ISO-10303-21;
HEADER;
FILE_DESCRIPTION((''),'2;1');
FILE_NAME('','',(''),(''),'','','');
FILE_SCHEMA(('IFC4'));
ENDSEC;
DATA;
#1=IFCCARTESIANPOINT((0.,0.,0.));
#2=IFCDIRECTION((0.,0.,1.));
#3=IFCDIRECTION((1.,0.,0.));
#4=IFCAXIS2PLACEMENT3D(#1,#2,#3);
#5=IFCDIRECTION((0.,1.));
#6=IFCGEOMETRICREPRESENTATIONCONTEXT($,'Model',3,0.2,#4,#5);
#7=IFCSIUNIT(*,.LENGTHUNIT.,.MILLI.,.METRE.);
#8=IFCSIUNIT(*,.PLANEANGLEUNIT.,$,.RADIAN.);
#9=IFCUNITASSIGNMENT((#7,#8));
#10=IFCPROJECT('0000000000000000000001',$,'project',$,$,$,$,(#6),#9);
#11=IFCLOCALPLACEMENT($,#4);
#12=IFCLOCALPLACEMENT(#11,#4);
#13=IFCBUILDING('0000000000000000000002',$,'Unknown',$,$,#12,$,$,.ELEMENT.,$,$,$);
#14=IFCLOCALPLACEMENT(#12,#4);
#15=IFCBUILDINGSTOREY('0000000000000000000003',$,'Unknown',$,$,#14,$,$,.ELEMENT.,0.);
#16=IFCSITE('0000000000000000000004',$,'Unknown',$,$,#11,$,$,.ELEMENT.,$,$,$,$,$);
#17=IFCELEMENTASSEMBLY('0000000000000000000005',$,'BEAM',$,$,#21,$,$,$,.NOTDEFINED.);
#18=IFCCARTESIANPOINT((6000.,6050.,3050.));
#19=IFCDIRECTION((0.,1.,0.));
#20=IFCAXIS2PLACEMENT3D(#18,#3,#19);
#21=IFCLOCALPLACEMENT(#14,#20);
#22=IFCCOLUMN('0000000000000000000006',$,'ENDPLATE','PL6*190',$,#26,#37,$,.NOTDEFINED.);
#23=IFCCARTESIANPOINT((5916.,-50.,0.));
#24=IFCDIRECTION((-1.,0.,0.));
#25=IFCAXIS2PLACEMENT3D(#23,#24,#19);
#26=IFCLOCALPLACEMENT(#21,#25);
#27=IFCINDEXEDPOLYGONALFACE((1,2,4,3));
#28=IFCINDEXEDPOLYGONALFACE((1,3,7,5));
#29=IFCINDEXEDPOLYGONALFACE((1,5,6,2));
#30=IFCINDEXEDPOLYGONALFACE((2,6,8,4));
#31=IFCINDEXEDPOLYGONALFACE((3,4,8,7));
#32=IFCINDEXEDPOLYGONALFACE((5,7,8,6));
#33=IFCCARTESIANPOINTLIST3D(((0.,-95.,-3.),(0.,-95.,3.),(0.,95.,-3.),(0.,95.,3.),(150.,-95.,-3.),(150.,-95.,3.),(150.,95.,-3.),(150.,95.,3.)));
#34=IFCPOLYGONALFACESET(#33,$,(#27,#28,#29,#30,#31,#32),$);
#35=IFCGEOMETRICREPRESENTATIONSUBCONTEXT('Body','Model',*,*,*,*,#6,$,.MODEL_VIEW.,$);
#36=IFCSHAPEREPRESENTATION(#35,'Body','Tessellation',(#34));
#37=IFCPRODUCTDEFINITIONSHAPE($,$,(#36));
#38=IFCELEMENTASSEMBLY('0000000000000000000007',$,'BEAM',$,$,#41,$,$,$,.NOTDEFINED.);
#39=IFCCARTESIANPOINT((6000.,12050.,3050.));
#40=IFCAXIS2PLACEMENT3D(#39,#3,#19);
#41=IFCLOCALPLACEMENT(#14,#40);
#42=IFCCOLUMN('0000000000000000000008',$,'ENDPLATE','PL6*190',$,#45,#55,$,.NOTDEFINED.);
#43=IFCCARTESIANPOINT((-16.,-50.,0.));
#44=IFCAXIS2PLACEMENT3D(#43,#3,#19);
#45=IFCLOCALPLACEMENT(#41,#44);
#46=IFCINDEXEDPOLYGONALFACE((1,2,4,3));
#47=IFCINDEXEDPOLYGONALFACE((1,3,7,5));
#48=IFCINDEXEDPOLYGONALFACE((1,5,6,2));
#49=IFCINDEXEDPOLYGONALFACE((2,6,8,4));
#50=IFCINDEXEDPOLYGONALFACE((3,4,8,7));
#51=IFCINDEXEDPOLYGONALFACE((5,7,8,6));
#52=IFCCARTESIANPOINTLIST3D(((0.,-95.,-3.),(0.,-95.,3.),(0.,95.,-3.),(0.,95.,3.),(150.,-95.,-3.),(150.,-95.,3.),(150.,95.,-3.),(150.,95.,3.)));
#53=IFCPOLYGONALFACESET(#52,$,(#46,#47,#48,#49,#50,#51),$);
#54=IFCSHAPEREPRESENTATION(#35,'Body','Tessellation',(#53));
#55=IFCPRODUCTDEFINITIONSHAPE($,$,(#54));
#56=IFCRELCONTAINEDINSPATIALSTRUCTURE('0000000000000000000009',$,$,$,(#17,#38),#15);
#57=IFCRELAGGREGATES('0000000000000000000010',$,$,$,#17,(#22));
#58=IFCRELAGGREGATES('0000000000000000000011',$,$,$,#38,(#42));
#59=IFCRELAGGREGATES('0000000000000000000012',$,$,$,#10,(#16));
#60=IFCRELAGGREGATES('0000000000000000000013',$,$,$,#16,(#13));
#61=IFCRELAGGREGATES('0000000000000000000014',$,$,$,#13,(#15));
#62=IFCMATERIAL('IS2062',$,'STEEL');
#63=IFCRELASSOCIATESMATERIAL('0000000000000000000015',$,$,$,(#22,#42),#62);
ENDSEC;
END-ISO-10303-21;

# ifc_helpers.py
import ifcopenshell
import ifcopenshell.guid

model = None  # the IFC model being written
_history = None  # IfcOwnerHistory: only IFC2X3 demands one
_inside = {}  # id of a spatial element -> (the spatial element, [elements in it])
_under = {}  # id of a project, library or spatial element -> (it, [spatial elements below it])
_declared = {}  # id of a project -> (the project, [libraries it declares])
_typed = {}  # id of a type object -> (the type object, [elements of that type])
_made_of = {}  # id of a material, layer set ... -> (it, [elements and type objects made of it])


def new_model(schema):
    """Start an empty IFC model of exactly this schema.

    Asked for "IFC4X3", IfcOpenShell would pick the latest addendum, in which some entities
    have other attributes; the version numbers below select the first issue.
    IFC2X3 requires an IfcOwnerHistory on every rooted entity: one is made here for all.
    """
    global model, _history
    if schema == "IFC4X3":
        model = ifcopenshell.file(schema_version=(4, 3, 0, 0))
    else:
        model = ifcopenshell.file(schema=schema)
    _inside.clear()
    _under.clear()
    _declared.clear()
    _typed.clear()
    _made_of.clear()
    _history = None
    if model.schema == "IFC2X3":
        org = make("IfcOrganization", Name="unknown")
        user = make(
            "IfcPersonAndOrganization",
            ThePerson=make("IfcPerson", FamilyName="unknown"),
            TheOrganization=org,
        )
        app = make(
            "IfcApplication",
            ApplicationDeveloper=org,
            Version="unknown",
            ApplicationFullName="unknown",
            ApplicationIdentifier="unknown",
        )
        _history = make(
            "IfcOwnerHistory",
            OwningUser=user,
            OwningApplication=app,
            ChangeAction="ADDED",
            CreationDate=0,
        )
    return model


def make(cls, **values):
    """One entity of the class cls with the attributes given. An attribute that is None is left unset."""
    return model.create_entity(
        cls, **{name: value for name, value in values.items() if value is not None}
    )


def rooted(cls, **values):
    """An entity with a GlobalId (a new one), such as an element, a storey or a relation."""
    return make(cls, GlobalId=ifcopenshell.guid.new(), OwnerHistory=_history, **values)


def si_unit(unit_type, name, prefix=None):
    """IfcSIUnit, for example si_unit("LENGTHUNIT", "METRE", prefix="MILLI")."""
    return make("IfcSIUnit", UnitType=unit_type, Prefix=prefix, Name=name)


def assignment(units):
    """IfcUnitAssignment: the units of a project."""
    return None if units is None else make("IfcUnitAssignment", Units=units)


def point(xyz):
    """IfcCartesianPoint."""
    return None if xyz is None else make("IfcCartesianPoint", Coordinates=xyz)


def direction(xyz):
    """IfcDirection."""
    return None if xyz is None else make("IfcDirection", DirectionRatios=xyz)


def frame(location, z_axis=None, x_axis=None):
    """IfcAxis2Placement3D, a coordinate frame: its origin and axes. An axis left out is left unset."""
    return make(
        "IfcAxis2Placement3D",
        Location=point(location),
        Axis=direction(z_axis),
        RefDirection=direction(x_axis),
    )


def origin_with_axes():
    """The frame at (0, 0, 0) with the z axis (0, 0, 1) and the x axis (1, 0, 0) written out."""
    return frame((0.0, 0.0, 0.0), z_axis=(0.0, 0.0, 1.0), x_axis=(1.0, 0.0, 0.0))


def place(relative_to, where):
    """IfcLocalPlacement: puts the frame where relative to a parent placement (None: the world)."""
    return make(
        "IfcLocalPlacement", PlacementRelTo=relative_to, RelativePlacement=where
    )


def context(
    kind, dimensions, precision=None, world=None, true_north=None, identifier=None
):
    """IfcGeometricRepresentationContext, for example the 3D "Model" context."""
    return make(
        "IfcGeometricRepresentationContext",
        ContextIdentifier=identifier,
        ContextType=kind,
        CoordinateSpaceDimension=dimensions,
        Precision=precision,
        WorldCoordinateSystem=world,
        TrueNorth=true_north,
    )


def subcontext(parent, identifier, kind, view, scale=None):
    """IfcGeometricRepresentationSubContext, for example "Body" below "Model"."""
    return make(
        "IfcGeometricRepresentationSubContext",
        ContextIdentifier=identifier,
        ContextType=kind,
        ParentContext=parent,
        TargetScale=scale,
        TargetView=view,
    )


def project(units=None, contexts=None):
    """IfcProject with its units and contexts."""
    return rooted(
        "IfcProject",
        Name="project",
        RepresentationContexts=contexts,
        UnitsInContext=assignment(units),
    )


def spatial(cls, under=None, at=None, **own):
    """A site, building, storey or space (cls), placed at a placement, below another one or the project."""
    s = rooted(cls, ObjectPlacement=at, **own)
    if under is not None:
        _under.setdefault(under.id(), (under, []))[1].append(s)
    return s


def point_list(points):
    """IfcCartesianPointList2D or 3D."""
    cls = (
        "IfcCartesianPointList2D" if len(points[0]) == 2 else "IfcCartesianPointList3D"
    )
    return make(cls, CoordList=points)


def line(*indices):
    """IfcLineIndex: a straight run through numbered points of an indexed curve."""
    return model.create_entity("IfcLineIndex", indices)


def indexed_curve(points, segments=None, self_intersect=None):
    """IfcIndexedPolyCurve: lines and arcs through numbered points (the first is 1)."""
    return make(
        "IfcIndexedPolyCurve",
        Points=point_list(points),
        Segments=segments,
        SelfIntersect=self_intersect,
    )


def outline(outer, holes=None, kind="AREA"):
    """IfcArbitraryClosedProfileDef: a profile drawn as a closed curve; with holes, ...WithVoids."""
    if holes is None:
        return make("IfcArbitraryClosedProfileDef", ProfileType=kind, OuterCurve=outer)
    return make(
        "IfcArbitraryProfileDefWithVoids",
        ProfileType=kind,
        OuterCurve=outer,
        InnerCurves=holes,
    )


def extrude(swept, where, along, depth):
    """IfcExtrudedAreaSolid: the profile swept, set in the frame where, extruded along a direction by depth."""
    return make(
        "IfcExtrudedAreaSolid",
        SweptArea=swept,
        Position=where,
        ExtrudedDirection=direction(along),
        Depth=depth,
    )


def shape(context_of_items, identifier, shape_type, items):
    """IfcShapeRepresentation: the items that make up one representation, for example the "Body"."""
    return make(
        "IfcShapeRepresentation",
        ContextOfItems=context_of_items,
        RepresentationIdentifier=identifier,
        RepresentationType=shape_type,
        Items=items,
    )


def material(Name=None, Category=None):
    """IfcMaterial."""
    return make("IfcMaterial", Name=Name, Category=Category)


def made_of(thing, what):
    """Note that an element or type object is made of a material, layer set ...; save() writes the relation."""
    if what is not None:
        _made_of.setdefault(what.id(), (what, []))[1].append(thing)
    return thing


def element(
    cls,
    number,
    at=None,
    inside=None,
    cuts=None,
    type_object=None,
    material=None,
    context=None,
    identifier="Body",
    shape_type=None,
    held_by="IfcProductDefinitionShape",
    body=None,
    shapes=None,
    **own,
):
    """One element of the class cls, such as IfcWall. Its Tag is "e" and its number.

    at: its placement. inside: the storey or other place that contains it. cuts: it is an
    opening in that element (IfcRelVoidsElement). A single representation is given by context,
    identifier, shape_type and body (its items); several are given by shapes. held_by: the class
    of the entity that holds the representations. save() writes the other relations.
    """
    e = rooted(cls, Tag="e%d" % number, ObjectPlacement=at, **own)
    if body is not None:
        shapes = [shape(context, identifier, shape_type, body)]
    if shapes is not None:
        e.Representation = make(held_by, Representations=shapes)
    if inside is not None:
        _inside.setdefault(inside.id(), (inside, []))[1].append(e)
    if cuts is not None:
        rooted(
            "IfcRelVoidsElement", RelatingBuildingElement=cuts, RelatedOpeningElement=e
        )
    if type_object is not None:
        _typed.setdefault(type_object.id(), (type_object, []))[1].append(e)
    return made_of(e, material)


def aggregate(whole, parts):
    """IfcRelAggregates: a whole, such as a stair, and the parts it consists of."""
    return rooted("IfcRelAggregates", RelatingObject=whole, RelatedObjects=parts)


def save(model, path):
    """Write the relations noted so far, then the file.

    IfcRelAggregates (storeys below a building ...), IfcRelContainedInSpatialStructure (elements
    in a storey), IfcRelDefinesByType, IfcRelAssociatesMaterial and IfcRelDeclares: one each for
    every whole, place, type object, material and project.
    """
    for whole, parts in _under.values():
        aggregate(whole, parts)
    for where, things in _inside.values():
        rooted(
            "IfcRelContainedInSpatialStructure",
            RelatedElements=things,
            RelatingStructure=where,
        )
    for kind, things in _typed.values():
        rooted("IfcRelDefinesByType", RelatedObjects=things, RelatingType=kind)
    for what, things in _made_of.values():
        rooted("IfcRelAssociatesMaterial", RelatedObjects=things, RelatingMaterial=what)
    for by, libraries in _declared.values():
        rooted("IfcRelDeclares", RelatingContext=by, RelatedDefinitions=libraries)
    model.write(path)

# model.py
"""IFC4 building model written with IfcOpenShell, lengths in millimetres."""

from ifc_helpers import new_model, si_unit, direction, frame, origin_with_axes, place, context, subcontext, project, spatial, line, indexed_curve, outline, extrude, material, element, aggregate, save


model = new_model("IFC4")

# Units and contexts
model_context = context("Model", 3, precision=0.2, world=origin_with_axes(), true_north=direction((0.0, 1.0)))
body_context = subcontext(model_context, "Body", "Model", "MODEL_VIEW")
ifc_project = project(units=[si_unit("LENGTHUNIT", "METRE", prefix="MILLI"), si_unit("PLANEANGLEUNIT", "RADIAN")], contexts=[model_context])

# Site, building, storey
site_placement = place(None, origin_with_axes())
site = spatial("IfcSite", under=ifc_project, at=site_placement, Name="Unknown", CompositionType="ELEMENT")
building_placement = place(site_placement, origin_with_axes())
building = spatial("IfcBuilding", under=site, at=building_placement, Name="Unknown", CompositionType="ELEMENT")
storey_placement = place(building_placement, origin_with_axes())
storey = spatial("IfcBuildingStorey", under=building, at=storey_placement, Name="Unknown", CompositionType="ELEMENT", Elevation=0.0)

# Element assemblies, columns
assembly_1_placement = place(storey_placement, frame((6000.0, 6050.0, 3050.0), z_axis=(1.0, 0.0, 0.0), x_axis=(0.0, 1.0, 0.0)))
assembly_1 = element("IfcElementAssembly", 1, at=assembly_1_placement, inside=storey, Name="BEAM", PredefinedType="NOTDEFINED")
ifc_material_1 = material(Name="IS2062", Category="STEEL")
column_1_placement = place(assembly_1_placement, frame((5916.0, -50.0, 0.0), z_axis=(-1.0, 0.0, 0.0), x_axis=(0.0, 1.0, 0.0)))
column_1 = element("IfcColumn", 2, at=column_1_placement, material=ifc_material_1, Name="ENDPLATE", Description="PL6*190", PredefinedType="NOTDEFINED", context=body_context, shape_type="SolidModel", body=[
    extrude(outline(indexed_curve([(-3.0, -95.0), (3.0, -95.0), (3.0, 95.0), (-3.0, 95.0)], segments=[line(1, 2, 3, 4, 1)])), frame((0.0, 0.0, 0.0), z_axis=(-1.0, 0.0, 0.0), x_axis=(0.0, 0.0, 1.0)), (0.0, 0.0, -1.0), 150.0),
])
assembly_2_placement = place(storey_placement, frame((6000.0, 12050.0, 3050.0), z_axis=(1.0, 0.0, 0.0), x_axis=(0.0, 1.0, 0.0)))
assembly_2 = element("IfcElementAssembly", 3, at=assembly_2_placement, inside=storey, Name="BEAM", PredefinedType="NOTDEFINED")
column_2_placement = place(assembly_2_placement, frame((-16.0, -50.0, 0.0), z_axis=(1.0, 0.0, 0.0), x_axis=(0.0, 1.0, 0.0)))
column_2 = element("IfcColumn", 4, at=column_2_placement, material=ifc_material_1, Name="ENDPLATE", Description="PL6*190", PredefinedType="NOTDEFINED", context=body_context, shape_type="SolidModel", body=[
    extrude(outline(indexed_curve([(-3.0, -95.0), (3.0, -95.0), (3.0, 95.0), (-3.0, 95.0)], segments=[line(1, 2, 3, 4, 1)])), frame((0.0, 0.0, 0.0), z_axis=(-1.0, 0.0, 0.0), x_axis=(0.0, 0.0, 1.0)), (0.0, 0.0, -1.0), 150.0),
])

aggregate(assembly_1, [column_1])
aggregate(assembly_2, [column_2])

save(model, "model.ifc")
